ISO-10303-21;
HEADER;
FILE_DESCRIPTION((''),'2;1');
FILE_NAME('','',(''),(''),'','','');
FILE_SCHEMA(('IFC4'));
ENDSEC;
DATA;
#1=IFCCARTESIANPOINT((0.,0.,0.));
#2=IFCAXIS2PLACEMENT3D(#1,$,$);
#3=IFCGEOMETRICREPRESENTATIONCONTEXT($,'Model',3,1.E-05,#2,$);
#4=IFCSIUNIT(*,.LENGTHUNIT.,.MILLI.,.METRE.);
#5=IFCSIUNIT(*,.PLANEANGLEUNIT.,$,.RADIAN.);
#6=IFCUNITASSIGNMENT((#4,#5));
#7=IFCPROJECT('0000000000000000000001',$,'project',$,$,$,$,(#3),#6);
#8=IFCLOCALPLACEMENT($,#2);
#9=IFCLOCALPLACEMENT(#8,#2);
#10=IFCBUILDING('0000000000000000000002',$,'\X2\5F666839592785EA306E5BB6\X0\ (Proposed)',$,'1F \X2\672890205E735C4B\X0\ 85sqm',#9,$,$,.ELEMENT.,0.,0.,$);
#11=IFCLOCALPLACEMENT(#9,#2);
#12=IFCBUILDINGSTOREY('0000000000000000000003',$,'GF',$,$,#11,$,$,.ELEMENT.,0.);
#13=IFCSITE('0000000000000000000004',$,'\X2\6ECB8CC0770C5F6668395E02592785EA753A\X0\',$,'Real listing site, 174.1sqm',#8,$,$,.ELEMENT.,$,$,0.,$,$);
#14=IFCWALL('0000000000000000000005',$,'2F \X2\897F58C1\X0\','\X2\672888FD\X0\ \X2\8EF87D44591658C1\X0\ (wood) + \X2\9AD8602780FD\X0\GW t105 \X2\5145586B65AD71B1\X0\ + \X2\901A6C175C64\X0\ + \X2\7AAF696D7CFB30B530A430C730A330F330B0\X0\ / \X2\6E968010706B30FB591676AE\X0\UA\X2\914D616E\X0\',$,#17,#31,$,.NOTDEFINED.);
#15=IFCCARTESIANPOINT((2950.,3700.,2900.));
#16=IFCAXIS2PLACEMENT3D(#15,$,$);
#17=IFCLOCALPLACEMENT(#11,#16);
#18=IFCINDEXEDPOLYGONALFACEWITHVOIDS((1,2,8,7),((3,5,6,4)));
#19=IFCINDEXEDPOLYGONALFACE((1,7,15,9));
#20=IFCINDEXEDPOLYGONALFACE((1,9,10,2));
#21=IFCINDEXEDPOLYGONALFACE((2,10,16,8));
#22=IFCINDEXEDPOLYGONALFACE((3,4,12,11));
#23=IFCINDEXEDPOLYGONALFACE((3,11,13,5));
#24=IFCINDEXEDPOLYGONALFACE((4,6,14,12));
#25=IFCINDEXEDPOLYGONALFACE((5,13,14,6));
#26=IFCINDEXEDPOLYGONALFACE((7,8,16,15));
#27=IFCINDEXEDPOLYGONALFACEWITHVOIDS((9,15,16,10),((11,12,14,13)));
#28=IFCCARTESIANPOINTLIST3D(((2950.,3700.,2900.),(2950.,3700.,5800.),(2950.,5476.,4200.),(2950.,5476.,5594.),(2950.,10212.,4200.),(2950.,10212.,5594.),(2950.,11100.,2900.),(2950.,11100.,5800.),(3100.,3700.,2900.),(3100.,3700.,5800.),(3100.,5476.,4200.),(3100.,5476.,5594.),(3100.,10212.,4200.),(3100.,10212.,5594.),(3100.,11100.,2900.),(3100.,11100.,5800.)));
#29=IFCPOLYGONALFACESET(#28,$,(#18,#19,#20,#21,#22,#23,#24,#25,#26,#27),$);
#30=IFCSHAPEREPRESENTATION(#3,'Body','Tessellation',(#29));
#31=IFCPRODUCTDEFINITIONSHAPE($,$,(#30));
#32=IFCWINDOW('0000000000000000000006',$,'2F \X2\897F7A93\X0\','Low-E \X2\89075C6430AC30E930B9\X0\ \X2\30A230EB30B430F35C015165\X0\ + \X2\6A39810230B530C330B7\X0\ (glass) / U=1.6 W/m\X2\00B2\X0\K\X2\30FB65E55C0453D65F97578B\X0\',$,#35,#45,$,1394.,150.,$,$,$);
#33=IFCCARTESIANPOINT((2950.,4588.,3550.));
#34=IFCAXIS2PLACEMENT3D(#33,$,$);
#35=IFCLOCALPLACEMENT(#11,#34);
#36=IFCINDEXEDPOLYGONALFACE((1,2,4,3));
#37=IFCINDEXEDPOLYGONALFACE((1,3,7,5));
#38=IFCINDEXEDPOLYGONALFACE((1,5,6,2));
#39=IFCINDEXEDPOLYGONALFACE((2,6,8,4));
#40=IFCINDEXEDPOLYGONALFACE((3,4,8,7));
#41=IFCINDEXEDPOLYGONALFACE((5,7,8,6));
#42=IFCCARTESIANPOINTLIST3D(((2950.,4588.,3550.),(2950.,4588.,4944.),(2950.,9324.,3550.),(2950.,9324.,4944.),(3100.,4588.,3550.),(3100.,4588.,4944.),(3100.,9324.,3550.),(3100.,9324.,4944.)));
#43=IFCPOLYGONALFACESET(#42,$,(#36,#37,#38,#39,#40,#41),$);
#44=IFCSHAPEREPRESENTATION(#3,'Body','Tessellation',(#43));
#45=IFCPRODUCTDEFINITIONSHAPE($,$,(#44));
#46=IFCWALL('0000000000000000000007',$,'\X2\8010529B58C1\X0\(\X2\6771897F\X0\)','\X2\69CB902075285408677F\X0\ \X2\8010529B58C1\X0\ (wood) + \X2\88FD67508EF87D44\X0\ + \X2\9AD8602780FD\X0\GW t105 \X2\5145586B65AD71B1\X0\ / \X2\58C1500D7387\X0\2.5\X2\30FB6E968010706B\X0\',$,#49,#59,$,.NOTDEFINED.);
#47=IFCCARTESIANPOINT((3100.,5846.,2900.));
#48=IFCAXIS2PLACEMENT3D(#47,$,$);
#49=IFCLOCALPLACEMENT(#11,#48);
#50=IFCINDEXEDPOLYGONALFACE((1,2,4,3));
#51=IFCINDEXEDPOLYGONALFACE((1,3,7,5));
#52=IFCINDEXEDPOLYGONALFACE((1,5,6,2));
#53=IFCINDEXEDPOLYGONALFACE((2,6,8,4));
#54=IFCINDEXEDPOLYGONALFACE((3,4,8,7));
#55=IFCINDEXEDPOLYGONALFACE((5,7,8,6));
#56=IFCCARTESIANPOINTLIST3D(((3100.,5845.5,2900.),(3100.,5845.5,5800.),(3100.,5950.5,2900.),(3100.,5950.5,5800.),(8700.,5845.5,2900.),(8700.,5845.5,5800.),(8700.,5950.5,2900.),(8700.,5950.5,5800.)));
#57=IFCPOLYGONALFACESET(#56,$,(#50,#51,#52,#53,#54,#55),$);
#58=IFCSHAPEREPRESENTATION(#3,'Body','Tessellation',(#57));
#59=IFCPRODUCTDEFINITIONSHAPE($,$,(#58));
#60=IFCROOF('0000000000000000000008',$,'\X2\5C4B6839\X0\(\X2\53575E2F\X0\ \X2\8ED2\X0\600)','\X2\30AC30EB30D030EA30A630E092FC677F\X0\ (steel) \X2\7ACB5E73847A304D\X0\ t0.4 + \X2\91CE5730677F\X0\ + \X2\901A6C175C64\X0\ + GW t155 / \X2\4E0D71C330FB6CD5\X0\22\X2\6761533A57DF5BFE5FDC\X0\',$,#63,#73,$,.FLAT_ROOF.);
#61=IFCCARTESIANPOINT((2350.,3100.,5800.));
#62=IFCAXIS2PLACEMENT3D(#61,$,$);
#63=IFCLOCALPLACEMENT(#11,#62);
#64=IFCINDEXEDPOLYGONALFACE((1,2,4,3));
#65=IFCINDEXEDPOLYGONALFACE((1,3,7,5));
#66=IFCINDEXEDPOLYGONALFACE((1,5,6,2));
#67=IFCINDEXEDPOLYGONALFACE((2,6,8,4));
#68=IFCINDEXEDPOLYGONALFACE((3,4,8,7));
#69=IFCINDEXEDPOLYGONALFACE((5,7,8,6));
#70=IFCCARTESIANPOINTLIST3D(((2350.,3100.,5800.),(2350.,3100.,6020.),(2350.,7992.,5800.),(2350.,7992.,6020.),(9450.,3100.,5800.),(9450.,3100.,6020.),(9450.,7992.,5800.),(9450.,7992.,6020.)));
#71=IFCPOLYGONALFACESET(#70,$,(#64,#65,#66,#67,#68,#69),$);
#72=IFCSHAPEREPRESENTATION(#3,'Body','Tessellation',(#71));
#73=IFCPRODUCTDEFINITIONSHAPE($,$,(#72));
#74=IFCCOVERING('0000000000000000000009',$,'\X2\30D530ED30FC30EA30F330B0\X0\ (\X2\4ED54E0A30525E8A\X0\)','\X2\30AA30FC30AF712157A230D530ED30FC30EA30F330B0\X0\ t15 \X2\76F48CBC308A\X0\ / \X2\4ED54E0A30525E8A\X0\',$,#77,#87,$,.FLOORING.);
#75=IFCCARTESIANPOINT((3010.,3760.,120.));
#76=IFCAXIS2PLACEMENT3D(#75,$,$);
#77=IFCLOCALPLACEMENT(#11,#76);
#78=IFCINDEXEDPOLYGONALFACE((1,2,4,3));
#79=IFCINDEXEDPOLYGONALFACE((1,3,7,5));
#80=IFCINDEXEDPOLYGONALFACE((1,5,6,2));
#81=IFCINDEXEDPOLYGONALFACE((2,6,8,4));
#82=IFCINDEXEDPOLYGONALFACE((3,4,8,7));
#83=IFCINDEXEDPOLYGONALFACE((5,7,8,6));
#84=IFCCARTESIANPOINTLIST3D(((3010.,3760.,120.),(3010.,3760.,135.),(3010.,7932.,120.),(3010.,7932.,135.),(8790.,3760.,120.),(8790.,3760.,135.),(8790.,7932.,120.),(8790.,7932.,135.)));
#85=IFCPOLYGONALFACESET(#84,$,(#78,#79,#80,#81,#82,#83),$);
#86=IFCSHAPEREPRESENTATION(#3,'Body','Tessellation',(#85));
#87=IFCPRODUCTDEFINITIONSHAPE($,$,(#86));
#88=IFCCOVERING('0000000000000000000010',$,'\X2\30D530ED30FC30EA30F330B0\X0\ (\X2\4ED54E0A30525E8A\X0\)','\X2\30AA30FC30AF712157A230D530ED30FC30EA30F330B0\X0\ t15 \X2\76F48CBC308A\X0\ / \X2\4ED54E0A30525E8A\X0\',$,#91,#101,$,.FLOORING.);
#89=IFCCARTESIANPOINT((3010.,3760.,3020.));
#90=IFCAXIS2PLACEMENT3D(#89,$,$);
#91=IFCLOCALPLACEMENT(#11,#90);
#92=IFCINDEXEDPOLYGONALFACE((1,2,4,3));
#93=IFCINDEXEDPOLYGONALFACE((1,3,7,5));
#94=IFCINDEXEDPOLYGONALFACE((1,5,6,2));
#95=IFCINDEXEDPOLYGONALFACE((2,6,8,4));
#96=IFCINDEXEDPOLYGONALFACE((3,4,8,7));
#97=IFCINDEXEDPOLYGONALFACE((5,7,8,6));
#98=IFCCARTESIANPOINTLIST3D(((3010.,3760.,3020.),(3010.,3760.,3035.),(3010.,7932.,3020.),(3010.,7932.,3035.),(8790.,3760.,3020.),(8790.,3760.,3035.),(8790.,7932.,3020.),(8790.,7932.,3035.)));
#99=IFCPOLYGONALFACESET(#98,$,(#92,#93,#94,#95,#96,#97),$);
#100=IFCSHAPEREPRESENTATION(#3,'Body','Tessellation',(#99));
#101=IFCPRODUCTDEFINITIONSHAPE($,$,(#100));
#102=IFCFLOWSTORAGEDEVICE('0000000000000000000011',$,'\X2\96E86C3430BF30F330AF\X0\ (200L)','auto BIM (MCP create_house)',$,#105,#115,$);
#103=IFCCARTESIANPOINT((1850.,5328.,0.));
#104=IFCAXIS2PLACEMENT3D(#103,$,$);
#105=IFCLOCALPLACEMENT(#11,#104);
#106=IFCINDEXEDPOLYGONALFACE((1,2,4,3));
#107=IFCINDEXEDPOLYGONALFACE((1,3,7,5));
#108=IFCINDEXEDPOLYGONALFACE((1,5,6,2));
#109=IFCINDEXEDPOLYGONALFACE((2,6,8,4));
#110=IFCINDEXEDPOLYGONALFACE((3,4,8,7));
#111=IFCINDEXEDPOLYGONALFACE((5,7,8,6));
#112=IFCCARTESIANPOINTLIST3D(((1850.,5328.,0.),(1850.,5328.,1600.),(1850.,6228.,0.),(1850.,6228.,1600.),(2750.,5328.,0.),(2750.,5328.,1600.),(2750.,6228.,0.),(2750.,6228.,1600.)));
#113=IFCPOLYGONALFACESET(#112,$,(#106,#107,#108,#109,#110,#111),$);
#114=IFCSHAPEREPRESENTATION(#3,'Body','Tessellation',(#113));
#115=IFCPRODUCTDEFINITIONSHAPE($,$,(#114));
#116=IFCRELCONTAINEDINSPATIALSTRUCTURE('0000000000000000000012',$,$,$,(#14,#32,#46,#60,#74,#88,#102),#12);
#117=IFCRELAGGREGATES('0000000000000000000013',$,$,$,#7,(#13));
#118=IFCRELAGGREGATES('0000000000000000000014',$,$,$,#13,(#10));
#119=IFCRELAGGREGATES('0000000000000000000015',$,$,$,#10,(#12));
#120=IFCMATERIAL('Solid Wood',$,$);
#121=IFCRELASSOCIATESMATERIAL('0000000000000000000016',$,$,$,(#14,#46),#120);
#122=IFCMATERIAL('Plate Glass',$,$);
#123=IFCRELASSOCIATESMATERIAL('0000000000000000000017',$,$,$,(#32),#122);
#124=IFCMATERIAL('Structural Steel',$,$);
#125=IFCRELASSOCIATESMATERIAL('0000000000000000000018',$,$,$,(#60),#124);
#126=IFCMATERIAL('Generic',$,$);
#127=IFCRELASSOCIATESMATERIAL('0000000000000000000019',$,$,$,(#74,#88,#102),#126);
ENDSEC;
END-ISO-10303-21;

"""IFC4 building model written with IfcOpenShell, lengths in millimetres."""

from ifc_helpers import new_model, si_unit, frame, frame_2d, origin, place, context, project, spatial, rectangle, extrude, material, element, fill, save


model = new_model("IFC4")

# Units and contexts
model_context = context("Model", 3, precision=1e-05, world=origin())
ifc_project = project(units=[si_unit("LENGTHUNIT", "METRE", prefix="MILLI"), si_unit("PLANEANGLEUNIT", "RADIAN")], contexts=[model_context])

# Site, building, storey
site_placement = place(None, origin())
site = spatial("IfcSite", under=ifc_project, at=site_placement, Name="滋賀県彦根市大藪町", ObjectType="Real listing site, 174.1sqm", CompositionType="ELEMENT", RefElevation=0.0)
building_placement = place(site_placement, origin())
building = spatial("IfcBuilding", under=site, at=building_placement, Name="彦根大藪の家 (Proposed)", ObjectType="1F 木造平屋 85sqm", CompositionType="ELEMENT", ElevationOfRefHeight=0.0, ElevationOfTerrain=0.0)
storey_placement = place(building_placement, origin())
storey = spatial("IfcBuildingStorey", under=building, at=storey_placement, Name="GF", CompositionType="ELEMENT", Elevation=0.0)

# Shared definitions
ifc_material_1 = material(Name="Solid Wood")
ifc_material_2 = material(Name="Generic")

# Shared definitions
ifc_material_3 = material(Name="Plate Glass")

# Wall, opening, window
wall_1_placement = place(storey_placement, frame((2950.0, 3700.0, 2900.0)))
wall_1 = element("IfcWall", 1, at=wall_1_placement, inside=storey, material=ifc_material_1, Name="2F 西壁", Description="木製 軸組外壁 (wood) + 高性能GW t105 充填断熱 + 通気層 + 窯業系サイディング / 準耐火・外皮UA配慮", PredefinedType="NOTDEFINED", context=model_context, shape_type="SweptSolid", body=[
    extrude(rectangle(XDim=150.0, YDim=7400.0, at=frame_2d((75.0, 3700.0))), frame((2950.0, 3700.0, 2900.0)), (0.0, 0.0, 1.0), 2900.0),
])
opening_1_placement = place(storey_placement, frame((2950.0, 4588.0, 3550.0)))
opening_1 = element("IfcOpeningElement", 2, at=opening_1_placement, cuts=wall_1, PredefinedType="NOTDEFINED", context=model_context, shape_type="SweptSolid", body=[
    extrude(rectangle(XDim=150.0, YDim=4736.0, at=frame_2d((75.0, 2368.0))), frame((2950.0, 4588.0, 3550.0)), (0.0, 0.0, 1.0), 1394.0),
])
window_1_placement = place(storey_placement, frame((2950.0, 4588.0, 3550.0)))
window_1 = element("IfcWindow", 3, at=window_1_placement, inside=storey, material=ifc_material_3, Name="2F 西窓", Description="Low-E 複層ガラス アルゴン封入 + 樹脂サッシ (glass) / U=1.6 W/m²K・日射取得型", OverallHeight=1394.0, OverallWidth=150.0, context=model_context, shape_type="SweptSolid", body=[
    extrude(rectangle(XDim=150.0, YDim=4736.0, at=frame_2d((75.0, 2368.0))), frame((2950.0, 4588.0, 3550.0)), (0.0, 0.0, 1.0), 1394.0),
])
fill(opening_1, window_1)

# Wall
wall_2_placement = place(storey_placement, frame((3100.0, 5846.0, 2900.0)))
element("IfcWall", 4, at=wall_2_placement, inside=storey, material=ifc_material_1, Name="耐力壁(東西)", Description="構造用合板 耐力壁 (wood) + 製材軸組 + 高性能GW t105 充填断熱 / 壁倍率2.5・準耐火", PredefinedType="NOTDEFINED", context=model_context, shape_type="SweptSolid", body=[
    extrude(rectangle(XDim=5600.0, YDim=105.0, at=frame_2d((2800.0, 52.0))), frame((3100.0, 5846.0, 2900.0)), (0.0, 0.0, 1.0), 2900.0),
])

# Roof
ifc_material_4 = material(Name="Structural Steel")
for number, where, name in (
    (5, (2350.0, 3100.0, 5800.0), "屋根(南帯 軒600)"),
):
    element("IfcRoof", number, at=place(storey_placement, frame(where)), inside=storey, material=ifc_material_4, Name=name, Description="ガルバリウム鋼板 (steel) 立平葺き t0.4 + 野地板 + 通気層 + GW t155 / 不燃・法22条区域対応", PredefinedType="FLAT_ROOF", context=model_context, shape_type="SweptSolid", body=[
        extrude(rectangle(XDim=7100.0, YDim=4892.0, at=frame_2d((3550.0, 2446.0))), frame((2350.0, 3100.0, 5800.0)), (0.0, 0.0, 1.0), 220.0),
    ])

# Coverings
covering_1_placement = place(storey_placement, frame((3010.0, 3760.0, 120.0)))
element("IfcCovering", 6, at=covering_1_placement, inside=storey, material=ifc_material_2, Name="フローリング (仕上げ床)", Description="オーク無垢フローリング t15 直貼り / 仕上げ床", PredefinedType="FLOORING", context=model_context, shape_type="SweptSolid", body=[
    extrude(rectangle(XDim=5780.0, YDim=4172.0, at=frame_2d((2890.0, 2086.0))), frame((3010.0, 3760.0, 120.0)), (0.0, 0.0, 1.0), 15.0),
])
covering_2_placement = place(storey_placement, frame((3010.0, 3760.0, 3020.0)))
element("IfcCovering", 7, at=covering_2_placement, inside=storey, material=ifc_material_2, Name="フローリング (仕上げ床)", Description="オーク無垢フローリング t15 直貼り / 仕上げ床", PredefinedType="FLOORING", context=model_context, shape_type="SweptSolid", body=[
    extrude(rectangle(XDim=5780.0, YDim=4172.0, at=frame_2d((2890.0, 2086.0))), frame((3010.0, 3760.0, 3020.0)), (0.0, 0.0, 1.0), 15.0),
])

# Flow storage device
flow_storage_device_placement = place(storey_placement, frame((1850.0, 5328.0, 0.0)))
element("IfcFlowStorageDevice", 8, at=flow_storage_device_placement, inside=storey, material=ifc_material_2, Name="雨水タンク (200L)", Description="auto BIM (MCP create_house)", context=model_context, shape_type="SweptSolid", body=[
    extrude(rectangle(XDim=900.0, YDim=900.0, at=frame_2d((450.0, 450.0))), frame((1850.0, 5328.0, 0.0)), (0.0, 0.0, 1.0), 1600.0),
])

save(model, "model.ifc")
